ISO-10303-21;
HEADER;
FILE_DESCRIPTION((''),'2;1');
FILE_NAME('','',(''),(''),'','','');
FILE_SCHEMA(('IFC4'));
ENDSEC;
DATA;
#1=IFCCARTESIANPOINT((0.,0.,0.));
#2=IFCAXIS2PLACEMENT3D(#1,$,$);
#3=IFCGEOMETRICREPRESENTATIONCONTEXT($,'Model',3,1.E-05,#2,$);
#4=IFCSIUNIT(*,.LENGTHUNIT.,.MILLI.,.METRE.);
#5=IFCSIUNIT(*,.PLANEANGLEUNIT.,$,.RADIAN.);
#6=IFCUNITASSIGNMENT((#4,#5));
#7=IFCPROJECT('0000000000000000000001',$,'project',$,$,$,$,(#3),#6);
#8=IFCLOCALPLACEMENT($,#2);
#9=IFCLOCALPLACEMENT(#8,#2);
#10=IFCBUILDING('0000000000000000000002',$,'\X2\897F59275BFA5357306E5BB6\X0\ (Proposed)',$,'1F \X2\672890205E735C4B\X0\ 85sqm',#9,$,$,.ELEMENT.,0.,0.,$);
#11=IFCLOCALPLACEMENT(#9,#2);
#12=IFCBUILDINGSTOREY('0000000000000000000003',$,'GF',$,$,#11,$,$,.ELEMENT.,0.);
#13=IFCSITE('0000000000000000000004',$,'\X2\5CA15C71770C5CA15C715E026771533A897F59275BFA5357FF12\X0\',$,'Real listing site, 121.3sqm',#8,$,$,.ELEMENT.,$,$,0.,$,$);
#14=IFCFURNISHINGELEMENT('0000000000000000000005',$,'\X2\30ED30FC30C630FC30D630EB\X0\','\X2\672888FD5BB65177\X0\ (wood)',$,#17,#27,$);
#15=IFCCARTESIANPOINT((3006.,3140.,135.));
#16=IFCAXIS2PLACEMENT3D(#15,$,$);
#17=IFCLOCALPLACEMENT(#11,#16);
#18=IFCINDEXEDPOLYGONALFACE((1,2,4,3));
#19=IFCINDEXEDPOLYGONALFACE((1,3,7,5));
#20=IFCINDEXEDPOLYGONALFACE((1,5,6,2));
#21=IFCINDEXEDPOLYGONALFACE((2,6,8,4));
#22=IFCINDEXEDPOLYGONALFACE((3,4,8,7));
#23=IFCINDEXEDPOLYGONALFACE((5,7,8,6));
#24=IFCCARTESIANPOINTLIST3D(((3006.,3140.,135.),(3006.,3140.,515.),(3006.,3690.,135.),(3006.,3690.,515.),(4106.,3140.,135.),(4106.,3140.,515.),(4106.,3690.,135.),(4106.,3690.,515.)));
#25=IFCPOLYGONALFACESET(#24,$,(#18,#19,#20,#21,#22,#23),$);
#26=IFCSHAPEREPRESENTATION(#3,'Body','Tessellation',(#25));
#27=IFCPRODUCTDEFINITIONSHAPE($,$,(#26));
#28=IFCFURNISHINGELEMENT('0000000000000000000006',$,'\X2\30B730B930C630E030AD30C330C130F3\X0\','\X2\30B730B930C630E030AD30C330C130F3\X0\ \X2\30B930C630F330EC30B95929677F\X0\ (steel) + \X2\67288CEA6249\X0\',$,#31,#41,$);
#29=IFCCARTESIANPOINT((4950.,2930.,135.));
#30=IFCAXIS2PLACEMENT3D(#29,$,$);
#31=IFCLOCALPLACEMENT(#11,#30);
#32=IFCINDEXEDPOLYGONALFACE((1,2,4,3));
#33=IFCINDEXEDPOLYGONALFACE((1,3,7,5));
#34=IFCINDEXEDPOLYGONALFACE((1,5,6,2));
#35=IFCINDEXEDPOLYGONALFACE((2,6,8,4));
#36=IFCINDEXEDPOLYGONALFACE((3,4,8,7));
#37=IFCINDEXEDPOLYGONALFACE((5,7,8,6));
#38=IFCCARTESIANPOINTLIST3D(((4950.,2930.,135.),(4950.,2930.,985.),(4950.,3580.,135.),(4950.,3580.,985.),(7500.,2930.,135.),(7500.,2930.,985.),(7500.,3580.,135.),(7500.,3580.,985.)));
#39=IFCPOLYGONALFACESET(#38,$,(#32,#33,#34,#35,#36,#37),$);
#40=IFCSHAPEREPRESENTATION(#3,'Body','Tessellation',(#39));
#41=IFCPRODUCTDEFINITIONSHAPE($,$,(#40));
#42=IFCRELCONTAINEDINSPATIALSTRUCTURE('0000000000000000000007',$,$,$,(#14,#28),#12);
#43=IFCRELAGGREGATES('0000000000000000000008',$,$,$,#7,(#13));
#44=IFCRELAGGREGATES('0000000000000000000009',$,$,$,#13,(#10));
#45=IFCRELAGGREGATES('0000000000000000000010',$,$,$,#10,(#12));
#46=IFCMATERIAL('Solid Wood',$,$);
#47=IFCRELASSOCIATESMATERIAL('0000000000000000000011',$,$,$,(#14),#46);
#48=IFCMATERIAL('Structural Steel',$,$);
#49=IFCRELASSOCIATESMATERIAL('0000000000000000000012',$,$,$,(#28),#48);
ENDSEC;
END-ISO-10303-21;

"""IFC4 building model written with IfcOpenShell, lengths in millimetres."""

from ifc_helpers import new_model, si_unit, frame, frame_2d, origin, place, context, project, spatial, rectangle, extrude, material, element, save


model = new_model("IFC4")

# Units and contexts
model_context = context("Model", 3, precision=1e-05, world=origin())
ifc_project = project(units=[si_unit("LENGTHUNIT", "METRE", prefix="MILLI"), si_unit("PLANEANGLEUNIT", "RADIAN")], contexts=[model_context])

# Site, building, storey
site_placement = place(None, origin())
site = spatial("IfcSite", under=ifc_project, at=site_placement, Name="岡山県岡山市東区西大寺南２", ObjectType="Real listing site, 121.3sqm", CompositionType="ELEMENT", RefElevation=0.0)
building_placement = place(site_placement, origin())
building = spatial("IfcBuilding", under=site, at=building_placement, Name="西大寺南の家 (Proposed)", ObjectType="1F 木造平屋 85sqm", CompositionType="ELEMENT", ElevationOfRefHeight=0.0, ElevationOfTerrain=0.0)
storey_placement = place(building_placement, origin())
storey = spatial("IfcBuildingStorey", under=building, at=storey_placement, Name="GF", CompositionType="ELEMENT", Elevation=0.0)

# Shared definitions
ifc_material_1 = material(Name="Solid Wood")

# Furnishing elements
furnishing_1_placement = place(storey_placement, frame((3006.0, 3140.0, 135.0)))
element("IfcFurnishingElement", 1, at=furnishing_1_placement, inside=storey, material=ifc_material_1, Name="ローテーブル", Description="木製家具 (wood)", context=model_context, shape_type="SweptSolid", body=[
    extrude(rectangle(XDim=1100.0, YDim=550.0, at=frame_2d((550.0, 275.0))), frame((3006.0, 3140.0, 135.0)), (0.0, 0.0, 1.0), 380.0),
])
ifc_material_2 = material(Name="Structural Steel")
furnishing_2_placement = place(storey_placement, frame((4950.0, 2930.0, 135.0)))
element("IfcFurnishingElement", 2, at=furnishing_2_placement, inside=storey, material=ifc_material_2, Name="システムキッチン", Description="システムキッチン ステンレス天板 (steel) + 木質扉", context=model_context, shape_type="SweptSolid", body=[
    extrude(rectangle(XDim=2550.0, YDim=650.0, at=frame_2d((1275.0, 325.0))), frame((4950.0, 2930.0, 135.0)), (0.0, 0.0, 1.0), 850.0),
])

save(model, "model.ifc")
